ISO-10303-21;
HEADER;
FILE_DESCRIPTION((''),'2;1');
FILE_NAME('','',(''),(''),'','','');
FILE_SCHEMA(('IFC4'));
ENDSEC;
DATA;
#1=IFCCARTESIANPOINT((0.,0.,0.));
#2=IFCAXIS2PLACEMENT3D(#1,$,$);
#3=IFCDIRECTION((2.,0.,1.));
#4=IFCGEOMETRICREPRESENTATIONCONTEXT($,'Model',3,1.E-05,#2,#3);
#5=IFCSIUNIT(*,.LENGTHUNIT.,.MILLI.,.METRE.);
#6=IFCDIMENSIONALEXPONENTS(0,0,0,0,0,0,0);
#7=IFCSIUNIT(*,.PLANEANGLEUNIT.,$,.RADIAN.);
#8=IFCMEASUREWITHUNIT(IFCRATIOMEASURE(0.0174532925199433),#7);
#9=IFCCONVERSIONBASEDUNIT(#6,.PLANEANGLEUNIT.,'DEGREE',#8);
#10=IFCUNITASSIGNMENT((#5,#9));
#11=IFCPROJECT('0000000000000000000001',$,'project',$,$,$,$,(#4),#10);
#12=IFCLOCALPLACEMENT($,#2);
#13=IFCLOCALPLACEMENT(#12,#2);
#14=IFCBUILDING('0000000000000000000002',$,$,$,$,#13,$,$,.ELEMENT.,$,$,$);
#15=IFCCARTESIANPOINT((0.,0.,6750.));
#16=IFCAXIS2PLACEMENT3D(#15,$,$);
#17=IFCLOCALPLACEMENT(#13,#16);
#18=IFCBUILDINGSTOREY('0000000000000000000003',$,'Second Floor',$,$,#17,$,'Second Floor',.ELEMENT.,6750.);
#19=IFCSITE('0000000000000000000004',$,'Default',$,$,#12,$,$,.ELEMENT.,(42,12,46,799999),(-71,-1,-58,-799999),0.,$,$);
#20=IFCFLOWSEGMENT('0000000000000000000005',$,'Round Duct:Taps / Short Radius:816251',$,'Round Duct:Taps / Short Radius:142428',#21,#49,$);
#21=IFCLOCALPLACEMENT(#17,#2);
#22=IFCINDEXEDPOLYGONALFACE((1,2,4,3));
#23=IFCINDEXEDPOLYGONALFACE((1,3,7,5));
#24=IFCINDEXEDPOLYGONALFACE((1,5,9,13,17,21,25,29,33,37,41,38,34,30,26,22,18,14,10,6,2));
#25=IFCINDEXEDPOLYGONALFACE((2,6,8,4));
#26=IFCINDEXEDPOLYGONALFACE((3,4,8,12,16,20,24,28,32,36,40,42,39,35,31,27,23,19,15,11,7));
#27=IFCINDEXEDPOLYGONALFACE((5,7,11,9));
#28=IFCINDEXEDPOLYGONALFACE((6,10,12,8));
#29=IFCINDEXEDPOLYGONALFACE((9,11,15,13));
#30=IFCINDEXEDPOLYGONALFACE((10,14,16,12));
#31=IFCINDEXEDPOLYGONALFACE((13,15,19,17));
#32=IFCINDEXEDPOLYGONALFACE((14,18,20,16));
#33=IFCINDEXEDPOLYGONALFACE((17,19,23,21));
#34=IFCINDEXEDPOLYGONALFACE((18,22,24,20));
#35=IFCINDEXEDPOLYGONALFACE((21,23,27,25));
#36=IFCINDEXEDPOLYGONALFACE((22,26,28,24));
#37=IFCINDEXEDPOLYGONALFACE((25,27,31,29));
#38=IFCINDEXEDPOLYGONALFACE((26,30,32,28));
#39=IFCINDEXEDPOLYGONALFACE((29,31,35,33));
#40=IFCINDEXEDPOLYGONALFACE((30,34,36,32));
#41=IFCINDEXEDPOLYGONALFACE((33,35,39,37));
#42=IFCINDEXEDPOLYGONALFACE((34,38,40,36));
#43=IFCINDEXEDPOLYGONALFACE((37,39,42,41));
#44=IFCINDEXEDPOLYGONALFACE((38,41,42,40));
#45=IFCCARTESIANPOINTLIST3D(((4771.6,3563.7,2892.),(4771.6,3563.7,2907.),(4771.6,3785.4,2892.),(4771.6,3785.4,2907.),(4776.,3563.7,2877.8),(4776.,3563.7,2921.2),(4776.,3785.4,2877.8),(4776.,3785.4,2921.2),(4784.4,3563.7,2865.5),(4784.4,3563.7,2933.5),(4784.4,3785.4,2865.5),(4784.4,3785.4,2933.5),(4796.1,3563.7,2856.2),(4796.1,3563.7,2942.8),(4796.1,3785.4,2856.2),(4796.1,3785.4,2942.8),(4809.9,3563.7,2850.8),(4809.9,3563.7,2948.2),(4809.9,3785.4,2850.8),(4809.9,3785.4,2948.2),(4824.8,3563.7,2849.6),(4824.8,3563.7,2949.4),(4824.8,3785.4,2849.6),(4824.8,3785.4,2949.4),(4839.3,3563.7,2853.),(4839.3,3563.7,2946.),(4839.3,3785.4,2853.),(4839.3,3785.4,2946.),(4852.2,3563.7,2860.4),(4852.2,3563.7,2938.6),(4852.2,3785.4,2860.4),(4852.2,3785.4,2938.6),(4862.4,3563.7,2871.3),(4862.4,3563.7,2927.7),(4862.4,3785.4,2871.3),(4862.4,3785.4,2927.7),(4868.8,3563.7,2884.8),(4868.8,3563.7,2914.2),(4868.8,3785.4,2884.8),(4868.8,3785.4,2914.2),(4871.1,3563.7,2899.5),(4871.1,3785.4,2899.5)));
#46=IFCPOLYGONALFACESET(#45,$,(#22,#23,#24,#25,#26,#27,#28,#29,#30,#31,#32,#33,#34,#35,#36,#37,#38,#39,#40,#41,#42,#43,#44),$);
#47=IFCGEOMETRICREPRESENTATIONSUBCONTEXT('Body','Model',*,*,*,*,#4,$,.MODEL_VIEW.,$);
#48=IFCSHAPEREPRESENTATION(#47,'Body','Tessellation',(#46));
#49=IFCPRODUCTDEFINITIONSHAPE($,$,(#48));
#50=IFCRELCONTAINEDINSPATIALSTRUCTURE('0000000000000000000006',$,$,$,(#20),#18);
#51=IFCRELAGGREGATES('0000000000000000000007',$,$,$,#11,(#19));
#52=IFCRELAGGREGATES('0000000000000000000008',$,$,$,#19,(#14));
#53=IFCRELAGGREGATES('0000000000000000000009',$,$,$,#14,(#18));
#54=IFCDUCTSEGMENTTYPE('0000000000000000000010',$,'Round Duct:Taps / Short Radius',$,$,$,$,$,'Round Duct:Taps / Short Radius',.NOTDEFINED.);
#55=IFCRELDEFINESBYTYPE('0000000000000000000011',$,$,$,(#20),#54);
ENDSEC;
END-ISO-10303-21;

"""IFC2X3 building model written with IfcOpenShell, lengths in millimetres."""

from ifc_helpers import new_model, entity, si_unit, converted_unit, direction, frame, origin, origin_2d_with_axis, place, context, subcontext, project, spatial, circle, extrude, type_object, element, save


model = new_model("IFC2X3")

# Units and contexts
model_context = context("Model", 3, precision=1e-05, world=origin(), true_north=direction((2.0, 0.0, 1.0)))
body_context = subcontext(model_context, "Body", "Model", "MODEL_VIEW")
ifc_project = project(units=[si_unit("LENGTHUNIT", "METRE", prefix="MILLI"), converted_unit("PLANEANGLEUNIT", "DEGREE", entity("IfcRatioMeasure", 0.0174532925199433), si_unit("PLANEANGLEUNIT", "RADIAN"), dimensions=[0, 0, 0, 0, 0, 0, 0])], contexts=[model_context])

# Site, building, storey
site_placement = place(None, origin())
site = spatial("IfcSite", under=ifc_project, at=site_placement, Name="Default", CompositionType="ELEMENT", RefLatitude=(42, 12, 46, 799999), RefLongitude=(-71, -1, -58, -799999), RefElevation=0.0)
building_placement = place(site_placement, origin())
building = spatial("IfcBuilding", under=site, at=building_placement, CompositionType="ELEMENT")
storey_placement = place(building_placement, frame((0.0, 0.0, 6750.0)))
storey = spatial("IfcBuildingStorey", under=building, at=storey_placement, Name="Second Floor", LongName="Second Floor", CompositionType="ELEMENT", Elevation=6750.0)

# Flow segment
duct_segment_type = type_object("IfcDuctSegmentType", Name="Round Duct:Taps / Short Radius", ElementType="Round Duct:Taps / Short Radius", PredefinedType="NOTDEFINED")
flow_segment_1_placement = place(storey_placement, origin())
element("IfcFlowSegment", 1, at=flow_segment_1_placement, inside=storey, type_object=duct_segment_type, Name="Round Duct:Taps / Short Radius:816251", ObjectType="Round Duct:Taps / Short Radius:142428", context=body_context, shape_type="SweptSolid", body=[
    extrude(circle(Radius=50.0, at=origin_2d_with_axis()), frame((4821.1, 3563.7, 2899.5), z_axis=(0.0, 1.0, 0.0), x_axis=(1.0, 0.0, 0.0)), (0.0, 0.0, 1.0), 221.8),
])

save(model, "model.ifc")
